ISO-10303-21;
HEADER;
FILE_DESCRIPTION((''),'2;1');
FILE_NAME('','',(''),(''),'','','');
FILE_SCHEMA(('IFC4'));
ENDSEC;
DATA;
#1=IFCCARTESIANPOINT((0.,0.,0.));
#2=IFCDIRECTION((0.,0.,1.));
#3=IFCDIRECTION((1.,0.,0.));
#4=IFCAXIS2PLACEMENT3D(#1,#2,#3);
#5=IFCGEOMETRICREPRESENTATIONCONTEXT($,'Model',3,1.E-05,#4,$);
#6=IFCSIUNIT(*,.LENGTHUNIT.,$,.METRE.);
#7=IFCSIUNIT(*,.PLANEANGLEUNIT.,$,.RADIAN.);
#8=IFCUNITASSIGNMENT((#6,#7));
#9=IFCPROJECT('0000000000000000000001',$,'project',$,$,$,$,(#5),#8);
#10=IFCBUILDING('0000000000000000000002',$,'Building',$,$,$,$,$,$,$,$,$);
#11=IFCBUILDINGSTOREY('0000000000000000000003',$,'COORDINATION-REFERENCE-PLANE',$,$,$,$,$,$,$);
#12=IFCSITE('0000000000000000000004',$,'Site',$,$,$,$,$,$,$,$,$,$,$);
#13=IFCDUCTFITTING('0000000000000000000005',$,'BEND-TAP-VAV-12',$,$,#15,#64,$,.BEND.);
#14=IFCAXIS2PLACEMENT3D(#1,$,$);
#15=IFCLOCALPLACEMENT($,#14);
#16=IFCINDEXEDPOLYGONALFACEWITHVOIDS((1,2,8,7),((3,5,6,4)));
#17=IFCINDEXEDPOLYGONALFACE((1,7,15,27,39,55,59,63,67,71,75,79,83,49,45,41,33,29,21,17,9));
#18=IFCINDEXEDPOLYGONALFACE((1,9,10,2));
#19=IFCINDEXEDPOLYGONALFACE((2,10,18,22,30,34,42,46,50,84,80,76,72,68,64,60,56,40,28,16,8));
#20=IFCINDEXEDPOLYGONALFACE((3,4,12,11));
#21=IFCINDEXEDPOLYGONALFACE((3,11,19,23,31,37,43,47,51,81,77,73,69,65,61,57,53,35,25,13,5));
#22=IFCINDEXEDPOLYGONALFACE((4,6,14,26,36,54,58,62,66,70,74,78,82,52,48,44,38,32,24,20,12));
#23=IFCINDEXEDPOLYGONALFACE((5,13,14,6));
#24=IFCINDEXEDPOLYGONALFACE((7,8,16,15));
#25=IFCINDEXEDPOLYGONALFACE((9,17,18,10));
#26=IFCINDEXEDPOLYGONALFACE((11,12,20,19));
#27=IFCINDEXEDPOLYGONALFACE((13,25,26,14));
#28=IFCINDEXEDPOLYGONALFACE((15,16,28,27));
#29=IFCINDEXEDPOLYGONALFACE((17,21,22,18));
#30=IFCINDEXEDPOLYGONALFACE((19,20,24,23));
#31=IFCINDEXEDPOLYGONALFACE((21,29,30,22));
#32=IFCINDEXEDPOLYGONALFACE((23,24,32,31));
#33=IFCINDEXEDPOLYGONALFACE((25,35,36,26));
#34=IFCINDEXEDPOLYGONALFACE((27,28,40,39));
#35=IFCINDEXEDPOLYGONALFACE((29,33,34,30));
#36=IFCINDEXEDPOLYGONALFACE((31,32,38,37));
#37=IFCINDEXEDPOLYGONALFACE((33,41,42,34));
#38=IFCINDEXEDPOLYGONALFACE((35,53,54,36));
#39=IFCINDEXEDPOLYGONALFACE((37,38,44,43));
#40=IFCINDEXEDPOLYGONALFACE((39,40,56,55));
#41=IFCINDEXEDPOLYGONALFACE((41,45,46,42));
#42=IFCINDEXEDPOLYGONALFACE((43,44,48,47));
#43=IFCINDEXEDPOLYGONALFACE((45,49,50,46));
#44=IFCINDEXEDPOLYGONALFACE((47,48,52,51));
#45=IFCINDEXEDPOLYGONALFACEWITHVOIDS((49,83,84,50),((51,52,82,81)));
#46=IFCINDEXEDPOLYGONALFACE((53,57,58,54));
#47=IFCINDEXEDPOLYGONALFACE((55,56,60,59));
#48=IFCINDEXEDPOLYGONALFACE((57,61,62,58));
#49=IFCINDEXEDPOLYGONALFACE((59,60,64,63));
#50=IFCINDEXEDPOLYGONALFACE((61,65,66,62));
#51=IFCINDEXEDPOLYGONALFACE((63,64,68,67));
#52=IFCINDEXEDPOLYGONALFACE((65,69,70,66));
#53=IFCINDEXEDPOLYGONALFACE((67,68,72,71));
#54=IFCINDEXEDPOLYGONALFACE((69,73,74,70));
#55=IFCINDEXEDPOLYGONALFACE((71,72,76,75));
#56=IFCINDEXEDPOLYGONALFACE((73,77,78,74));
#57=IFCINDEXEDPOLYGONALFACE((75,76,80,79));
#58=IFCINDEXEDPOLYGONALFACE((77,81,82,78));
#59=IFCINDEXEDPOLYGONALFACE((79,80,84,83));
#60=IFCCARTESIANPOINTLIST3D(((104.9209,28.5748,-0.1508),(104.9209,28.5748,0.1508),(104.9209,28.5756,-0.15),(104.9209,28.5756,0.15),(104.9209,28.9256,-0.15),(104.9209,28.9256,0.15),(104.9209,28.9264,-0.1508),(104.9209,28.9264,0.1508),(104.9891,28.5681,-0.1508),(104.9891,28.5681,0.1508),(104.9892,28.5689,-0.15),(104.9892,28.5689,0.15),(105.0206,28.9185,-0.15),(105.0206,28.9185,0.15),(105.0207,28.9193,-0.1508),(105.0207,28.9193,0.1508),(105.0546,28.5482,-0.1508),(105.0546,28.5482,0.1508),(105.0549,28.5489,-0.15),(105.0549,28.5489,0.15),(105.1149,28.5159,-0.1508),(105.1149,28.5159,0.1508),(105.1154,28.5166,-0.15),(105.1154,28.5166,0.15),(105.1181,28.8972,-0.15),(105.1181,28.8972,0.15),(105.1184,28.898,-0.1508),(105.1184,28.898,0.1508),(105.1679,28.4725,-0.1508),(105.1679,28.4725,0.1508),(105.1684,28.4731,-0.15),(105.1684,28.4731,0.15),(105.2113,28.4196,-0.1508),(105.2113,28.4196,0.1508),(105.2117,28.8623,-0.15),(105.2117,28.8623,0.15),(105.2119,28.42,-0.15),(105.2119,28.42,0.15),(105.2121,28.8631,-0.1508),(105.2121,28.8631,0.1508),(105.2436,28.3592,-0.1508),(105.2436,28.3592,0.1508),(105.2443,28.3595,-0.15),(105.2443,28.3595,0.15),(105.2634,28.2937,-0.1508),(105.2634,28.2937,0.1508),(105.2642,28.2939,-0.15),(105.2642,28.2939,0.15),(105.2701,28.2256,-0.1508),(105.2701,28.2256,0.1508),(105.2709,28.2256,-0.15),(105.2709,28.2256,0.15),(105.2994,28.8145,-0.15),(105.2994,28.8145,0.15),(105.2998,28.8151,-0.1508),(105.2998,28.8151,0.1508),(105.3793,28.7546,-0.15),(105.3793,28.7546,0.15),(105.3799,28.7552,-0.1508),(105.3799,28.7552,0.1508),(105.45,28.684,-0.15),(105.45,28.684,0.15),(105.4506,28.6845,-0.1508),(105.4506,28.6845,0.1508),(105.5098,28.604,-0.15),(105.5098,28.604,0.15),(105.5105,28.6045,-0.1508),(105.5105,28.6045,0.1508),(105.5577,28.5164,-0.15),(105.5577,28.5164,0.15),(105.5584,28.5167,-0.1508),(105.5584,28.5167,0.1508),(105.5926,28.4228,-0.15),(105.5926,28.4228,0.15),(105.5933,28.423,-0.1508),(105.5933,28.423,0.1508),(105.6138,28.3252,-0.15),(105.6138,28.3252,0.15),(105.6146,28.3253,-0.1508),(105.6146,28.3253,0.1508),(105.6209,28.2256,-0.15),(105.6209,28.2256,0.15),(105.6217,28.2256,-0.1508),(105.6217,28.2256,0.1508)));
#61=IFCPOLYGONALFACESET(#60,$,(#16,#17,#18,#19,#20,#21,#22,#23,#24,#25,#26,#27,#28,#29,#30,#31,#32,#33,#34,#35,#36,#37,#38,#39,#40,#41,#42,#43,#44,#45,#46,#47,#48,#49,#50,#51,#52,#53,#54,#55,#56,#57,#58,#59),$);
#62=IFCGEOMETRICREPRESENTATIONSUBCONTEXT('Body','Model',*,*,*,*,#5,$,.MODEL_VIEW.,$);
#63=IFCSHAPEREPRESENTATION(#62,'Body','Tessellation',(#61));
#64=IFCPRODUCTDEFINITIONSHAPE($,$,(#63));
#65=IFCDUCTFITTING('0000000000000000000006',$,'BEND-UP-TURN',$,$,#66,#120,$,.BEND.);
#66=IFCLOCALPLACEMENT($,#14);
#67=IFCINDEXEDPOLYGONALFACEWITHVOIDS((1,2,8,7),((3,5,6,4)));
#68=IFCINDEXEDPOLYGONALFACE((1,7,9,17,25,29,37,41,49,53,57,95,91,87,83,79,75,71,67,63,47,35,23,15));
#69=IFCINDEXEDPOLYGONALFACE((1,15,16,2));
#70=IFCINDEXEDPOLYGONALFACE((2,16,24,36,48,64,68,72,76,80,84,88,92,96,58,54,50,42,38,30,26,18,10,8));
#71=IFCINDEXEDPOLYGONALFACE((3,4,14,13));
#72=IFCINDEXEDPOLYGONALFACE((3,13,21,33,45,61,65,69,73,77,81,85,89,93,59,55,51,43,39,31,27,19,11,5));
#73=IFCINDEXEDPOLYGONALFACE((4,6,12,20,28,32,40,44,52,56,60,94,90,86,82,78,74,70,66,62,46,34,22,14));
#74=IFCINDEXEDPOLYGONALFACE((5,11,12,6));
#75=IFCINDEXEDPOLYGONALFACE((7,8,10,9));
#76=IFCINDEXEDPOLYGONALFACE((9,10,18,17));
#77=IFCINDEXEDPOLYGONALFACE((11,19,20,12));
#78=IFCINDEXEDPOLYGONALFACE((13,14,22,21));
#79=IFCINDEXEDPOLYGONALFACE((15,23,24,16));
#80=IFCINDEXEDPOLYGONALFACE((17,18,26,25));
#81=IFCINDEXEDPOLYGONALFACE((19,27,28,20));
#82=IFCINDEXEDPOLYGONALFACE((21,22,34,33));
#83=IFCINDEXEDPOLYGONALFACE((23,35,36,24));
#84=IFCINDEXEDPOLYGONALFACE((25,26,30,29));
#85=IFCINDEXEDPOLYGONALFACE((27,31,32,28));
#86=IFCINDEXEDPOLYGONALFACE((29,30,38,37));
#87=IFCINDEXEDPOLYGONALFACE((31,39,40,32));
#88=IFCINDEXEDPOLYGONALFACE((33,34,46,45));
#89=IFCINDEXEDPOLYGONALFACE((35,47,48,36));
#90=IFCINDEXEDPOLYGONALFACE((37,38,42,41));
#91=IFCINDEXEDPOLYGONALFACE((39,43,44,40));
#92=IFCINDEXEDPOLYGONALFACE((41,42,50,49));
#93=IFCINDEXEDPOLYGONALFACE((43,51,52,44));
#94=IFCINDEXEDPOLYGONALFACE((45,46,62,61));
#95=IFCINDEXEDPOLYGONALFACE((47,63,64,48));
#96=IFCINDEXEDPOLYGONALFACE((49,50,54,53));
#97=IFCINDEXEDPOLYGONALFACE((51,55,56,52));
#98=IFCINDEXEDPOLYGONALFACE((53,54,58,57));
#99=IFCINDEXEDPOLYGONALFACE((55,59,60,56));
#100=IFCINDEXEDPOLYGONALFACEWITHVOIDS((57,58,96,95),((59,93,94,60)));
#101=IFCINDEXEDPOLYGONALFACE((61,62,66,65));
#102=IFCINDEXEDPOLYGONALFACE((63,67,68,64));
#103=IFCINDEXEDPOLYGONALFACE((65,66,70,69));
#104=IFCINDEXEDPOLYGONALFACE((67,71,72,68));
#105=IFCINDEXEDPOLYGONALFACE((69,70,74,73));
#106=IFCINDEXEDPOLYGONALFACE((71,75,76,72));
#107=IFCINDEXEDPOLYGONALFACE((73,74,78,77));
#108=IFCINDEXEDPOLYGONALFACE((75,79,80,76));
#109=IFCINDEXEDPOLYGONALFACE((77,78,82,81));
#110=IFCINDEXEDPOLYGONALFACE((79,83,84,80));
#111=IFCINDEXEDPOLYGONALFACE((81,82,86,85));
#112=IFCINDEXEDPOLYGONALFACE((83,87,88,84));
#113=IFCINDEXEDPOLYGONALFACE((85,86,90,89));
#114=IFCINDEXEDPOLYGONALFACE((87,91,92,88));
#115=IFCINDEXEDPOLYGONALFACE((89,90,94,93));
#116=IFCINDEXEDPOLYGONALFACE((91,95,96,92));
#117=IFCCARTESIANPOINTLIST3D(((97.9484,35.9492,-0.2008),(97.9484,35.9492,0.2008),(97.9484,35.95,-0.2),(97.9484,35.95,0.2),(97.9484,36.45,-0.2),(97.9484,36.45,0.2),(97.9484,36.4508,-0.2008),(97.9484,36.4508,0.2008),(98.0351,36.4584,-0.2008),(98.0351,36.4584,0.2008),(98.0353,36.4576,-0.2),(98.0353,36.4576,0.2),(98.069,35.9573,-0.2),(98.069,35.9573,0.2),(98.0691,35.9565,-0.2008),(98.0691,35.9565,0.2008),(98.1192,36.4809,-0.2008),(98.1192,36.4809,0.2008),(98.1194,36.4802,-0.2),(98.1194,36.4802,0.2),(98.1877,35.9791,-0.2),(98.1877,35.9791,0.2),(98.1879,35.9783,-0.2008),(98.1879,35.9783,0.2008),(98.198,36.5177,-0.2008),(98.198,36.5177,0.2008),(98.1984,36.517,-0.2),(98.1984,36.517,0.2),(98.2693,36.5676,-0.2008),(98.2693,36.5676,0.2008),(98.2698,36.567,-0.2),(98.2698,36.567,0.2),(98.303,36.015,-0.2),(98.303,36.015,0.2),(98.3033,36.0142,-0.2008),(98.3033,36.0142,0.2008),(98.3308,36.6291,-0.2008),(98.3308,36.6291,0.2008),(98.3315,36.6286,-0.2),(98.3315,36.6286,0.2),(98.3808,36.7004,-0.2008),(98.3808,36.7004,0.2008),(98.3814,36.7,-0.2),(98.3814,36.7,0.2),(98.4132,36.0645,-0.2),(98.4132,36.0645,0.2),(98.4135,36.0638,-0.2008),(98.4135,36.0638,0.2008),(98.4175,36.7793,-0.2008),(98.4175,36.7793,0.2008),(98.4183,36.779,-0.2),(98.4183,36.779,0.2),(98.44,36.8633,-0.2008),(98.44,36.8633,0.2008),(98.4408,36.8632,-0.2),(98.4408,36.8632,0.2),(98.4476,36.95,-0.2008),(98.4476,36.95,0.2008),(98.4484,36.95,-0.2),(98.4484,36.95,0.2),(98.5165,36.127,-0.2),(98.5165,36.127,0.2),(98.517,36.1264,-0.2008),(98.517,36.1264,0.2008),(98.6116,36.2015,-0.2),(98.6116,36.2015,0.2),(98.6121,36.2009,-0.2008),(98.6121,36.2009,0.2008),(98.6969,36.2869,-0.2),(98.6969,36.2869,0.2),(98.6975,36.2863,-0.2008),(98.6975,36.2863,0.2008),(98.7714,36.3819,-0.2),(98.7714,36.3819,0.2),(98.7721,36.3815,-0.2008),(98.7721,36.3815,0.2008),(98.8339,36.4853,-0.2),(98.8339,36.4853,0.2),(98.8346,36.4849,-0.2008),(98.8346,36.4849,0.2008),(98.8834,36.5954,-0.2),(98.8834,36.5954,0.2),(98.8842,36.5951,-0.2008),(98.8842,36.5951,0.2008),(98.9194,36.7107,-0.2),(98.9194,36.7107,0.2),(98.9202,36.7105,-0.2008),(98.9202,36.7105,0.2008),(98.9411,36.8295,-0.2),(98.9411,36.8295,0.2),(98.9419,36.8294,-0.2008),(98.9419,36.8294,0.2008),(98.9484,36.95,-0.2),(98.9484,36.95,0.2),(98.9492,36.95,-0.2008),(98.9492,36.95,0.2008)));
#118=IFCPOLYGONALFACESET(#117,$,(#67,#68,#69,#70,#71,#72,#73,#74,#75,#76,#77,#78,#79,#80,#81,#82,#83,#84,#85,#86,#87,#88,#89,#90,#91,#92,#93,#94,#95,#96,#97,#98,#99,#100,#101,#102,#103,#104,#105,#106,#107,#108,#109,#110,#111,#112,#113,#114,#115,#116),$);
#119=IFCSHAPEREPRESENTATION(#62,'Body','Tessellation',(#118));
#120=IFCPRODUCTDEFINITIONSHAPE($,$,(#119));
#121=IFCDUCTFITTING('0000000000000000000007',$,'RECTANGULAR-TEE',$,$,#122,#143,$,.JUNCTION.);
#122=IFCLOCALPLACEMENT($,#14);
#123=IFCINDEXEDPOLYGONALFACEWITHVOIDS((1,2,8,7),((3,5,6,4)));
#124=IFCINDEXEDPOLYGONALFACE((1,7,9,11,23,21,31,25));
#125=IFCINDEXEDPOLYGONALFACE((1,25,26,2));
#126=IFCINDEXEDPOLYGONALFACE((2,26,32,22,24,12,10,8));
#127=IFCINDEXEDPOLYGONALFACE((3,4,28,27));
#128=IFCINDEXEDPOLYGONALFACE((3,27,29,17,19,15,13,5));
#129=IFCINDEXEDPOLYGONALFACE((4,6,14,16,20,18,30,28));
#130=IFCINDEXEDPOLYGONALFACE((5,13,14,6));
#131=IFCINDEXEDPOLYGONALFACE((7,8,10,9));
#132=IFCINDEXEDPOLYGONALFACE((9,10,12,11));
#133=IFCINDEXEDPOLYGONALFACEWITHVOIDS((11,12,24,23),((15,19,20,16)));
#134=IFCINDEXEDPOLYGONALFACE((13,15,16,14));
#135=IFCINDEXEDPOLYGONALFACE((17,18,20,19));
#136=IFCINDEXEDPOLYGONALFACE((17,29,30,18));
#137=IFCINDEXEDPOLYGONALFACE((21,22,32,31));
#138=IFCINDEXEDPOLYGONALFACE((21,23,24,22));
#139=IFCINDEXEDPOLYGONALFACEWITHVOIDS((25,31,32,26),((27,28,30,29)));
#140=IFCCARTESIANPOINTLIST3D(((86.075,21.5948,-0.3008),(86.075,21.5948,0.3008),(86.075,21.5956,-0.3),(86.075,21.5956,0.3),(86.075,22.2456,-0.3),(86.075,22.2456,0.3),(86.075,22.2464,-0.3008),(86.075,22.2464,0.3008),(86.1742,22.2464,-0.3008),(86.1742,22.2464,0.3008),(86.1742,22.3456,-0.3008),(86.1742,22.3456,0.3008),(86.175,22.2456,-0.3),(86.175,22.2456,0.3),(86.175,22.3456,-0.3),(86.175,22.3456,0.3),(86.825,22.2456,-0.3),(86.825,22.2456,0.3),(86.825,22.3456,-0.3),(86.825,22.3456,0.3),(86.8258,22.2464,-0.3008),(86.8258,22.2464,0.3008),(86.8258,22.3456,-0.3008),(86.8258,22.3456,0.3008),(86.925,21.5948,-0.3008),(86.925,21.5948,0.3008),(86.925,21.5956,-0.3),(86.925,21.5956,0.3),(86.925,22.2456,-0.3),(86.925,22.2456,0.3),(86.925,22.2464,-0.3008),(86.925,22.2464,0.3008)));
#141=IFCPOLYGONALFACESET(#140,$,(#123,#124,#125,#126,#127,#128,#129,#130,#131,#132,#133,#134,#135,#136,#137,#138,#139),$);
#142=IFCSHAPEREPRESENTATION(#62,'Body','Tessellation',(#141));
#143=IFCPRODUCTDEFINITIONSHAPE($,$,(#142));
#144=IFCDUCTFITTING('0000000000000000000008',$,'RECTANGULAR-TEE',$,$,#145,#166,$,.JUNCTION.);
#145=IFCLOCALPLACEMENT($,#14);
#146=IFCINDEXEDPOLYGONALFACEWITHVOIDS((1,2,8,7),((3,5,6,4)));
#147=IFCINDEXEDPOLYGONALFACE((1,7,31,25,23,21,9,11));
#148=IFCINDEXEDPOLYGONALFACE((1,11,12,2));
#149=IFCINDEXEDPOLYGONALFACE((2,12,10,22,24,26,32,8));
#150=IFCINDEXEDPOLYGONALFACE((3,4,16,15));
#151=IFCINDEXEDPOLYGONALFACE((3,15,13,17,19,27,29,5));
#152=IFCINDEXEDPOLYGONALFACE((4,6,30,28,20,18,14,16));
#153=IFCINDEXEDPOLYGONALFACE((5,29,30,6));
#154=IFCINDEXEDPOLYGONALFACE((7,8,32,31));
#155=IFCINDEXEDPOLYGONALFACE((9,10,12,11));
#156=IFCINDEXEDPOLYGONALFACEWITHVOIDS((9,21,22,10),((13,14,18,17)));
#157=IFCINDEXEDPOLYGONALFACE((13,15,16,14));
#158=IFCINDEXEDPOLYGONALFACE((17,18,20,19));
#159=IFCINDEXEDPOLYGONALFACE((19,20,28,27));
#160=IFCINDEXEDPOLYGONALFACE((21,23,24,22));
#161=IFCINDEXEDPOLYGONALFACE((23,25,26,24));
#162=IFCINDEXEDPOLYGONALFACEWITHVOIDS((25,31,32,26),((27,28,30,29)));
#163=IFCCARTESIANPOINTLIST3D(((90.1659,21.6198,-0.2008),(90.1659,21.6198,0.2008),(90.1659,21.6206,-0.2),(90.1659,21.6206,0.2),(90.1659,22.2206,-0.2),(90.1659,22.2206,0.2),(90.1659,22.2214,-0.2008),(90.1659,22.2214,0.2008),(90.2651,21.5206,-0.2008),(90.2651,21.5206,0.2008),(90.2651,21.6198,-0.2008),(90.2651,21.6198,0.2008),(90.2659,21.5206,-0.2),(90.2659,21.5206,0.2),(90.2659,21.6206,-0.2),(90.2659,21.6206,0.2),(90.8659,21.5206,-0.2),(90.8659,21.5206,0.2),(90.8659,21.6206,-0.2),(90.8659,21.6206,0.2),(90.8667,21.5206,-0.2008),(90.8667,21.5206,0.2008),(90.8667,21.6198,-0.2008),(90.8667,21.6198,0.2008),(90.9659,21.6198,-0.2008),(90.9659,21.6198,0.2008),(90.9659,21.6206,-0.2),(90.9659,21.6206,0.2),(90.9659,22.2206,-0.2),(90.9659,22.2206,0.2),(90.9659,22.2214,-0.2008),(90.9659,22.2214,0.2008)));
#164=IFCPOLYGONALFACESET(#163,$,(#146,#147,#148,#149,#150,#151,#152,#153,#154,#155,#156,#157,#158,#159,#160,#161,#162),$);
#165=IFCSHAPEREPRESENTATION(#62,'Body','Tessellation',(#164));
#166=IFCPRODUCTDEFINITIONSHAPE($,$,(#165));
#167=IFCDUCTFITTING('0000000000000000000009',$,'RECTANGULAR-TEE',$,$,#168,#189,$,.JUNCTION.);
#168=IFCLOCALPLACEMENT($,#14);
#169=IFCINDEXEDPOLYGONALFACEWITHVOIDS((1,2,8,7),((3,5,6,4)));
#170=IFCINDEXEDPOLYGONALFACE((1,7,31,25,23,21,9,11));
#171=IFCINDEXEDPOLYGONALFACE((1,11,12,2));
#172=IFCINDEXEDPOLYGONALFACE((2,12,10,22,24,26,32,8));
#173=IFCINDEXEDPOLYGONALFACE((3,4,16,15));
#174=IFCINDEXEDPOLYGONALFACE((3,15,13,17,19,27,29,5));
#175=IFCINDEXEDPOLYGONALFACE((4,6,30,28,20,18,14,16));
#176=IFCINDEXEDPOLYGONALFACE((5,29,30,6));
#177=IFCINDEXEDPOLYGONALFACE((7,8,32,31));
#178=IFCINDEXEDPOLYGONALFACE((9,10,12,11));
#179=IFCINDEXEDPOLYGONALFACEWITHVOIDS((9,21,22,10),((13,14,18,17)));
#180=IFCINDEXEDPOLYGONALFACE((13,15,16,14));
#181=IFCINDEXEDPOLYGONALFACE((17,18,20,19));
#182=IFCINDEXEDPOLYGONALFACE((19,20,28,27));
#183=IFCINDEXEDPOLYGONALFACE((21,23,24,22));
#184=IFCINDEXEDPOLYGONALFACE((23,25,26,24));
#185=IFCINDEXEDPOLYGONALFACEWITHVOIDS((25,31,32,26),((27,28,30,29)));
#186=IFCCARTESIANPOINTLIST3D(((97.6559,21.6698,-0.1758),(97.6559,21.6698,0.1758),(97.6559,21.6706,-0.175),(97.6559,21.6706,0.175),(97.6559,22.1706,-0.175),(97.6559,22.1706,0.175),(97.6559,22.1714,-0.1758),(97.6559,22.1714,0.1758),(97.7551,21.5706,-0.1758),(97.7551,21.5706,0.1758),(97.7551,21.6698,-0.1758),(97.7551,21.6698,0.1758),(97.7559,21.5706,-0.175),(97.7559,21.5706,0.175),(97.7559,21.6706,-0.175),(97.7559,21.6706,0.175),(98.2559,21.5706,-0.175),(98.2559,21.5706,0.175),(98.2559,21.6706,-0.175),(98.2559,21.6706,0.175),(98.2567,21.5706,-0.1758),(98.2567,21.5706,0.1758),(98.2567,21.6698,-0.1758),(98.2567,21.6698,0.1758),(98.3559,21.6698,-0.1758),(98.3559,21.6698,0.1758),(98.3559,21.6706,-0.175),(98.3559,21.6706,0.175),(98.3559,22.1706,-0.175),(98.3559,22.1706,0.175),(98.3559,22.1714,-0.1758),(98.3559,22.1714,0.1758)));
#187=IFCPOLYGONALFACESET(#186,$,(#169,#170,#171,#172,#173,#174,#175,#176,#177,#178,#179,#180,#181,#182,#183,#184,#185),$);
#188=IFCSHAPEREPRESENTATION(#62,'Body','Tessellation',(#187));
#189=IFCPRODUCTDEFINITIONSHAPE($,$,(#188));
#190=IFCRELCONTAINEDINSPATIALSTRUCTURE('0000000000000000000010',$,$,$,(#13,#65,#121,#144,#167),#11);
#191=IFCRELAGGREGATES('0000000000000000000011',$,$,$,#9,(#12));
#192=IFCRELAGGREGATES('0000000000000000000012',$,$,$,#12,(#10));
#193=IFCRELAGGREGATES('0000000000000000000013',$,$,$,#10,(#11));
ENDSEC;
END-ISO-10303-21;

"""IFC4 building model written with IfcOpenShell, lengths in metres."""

from ifc_helpers import new_model, entity, si_unit, frame, origin_with_axes, place, context, subcontext, project, spatial, rectangle, extrude, boolean, element, save


model = new_model("IFC4")

# Units and contexts
model_context = context("Model", 3, precision=1e-05, world=origin_with_axes())
body_context = subcontext(model_context, "Body", "Model", "MODEL_VIEW")
ifc_project = project(units=[si_unit("LENGTHUNIT", "METRE"), si_unit("PLANEANGLEUNIT", "RADIAN")], contexts=[model_context])

# Site, building, storey
site = spatial("IfcSite", under=ifc_project, Name="Site")
building = spatial("IfcBuilding", under=site, Name="Building")
storey = spatial("IfcBuildingStorey", under=building, Name="COORDINATION-REFERENCE-PLANE")

# Duct fittings
duct_fitting_1_placement = place(None, frame((104.9209, 28.2256, 0.0), z_axis=(0.0, 0.0, -1.0), x_axis=(0.0, 1.0, 0.0)))
cartesian_point_1 = entity("IfcCartesianPoint", [0.0, 0.0, 0.0])
element("IfcDuctFitting", 1, at=duct_fitting_1_placement, inside=storey, Name="BEND-TAP-VAV-12", PredefinedType="BEND", context=body_context, shape_type="SweptSolid", body=[
    entity("IfcRevolvedAreaSolid", entity("IfcRectangleHollowProfileDef", "AREA", None, entity("IfcAxis2Placement2D", entity("IfcCartesianPoint", [0.525, 0.0])), 0.3516, 0.3016, 0.0008), entity("IfcAxis2Placement3D", cartesian_point_1, entity("IfcDirection", [0.0, -1.0, 0.0]), entity("IfcDirection", [1.0, 0.0, 0.0])), entity("IfcAxis1Placement", cartesian_point_1, entity("IfcDirection", [0.0, 1.0, 0.0])), 1.570796),
])
duct_fitting_2_placement = place(None, frame((97.9484, 36.95, 0.0), z_axis=(0.0, 0.0, 1.0), x_axis=(0.0, -1.0, 0.0)))
cartesian_point_2 = entity("IfcCartesianPoint", [0.0, 0.0, 0.0])
element("IfcDuctFitting", 2, at=duct_fitting_2_placement, inside=storey, Name="BEND-UP-TURN", PredefinedType="BEND", context=body_context, shape_type="SweptSolid", body=[
    entity("IfcRevolvedAreaSolid", entity("IfcRectangleHollowProfileDef", "AREA", None, entity("IfcAxis2Placement2D", entity("IfcCartesianPoint", [0.75, 0.0])), 0.5016, 0.4016, 0.0008), entity("IfcAxis2Placement3D", cartesian_point_2, entity("IfcDirection", [0.0, -1.0, 0.0]), entity("IfcDirection", [1.0, 0.0, 0.0])), entity("IfcAxis1Placement", cartesian_point_2, entity("IfcDirection", [0.0, 1.0, 0.0])), 1.570796),
])
duct_fitting_3_placement = place(None, frame((86.5, 21.9206, 0.0), z_axis=(1.0, 0.0, 0.0), x_axis=(0.0, 1.0, 0.0)))
solid_1 = boolean("UNION", extrude(rectangle(XDim=0.65, YDim=0.6), frame((0.0, 0.0, -0.425), z_axis=(0.0, 0.0, 1.0), x_axis=(1.0, 0.0, 0.0)), (0.0, 0.0, 1.0), 0.85), extrude(rectangle(XDim=0.65, YDim=0.6), frame((0.0, 0.0, 0.0), z_axis=(1.0, 0.0, 0.0), x_axis=(0.0, 0.0, -1.0)), (0.0, 0.0, 1.0), 0.425))
element("IfcDuctFitting", 3, at=duct_fitting_3_placement, inside=storey, Name="RECTANGULAR-TEE", PredefinedType="JUNCTION", context=body_context, shape_type="CSG", body=[
    boolean("DIFFERENCE", boolean("UNION", extrude(rectangle(XDim=0.6516, YDim=0.6016), frame((0.0, 0.0, -0.425), z_axis=(0.0, 0.0, 1.0), x_axis=(1.0, 0.0, 0.0)), (0.0, 0.0, 1.0), 0.85), extrude(rectangle(XDim=0.6516, YDim=0.6016), frame((0.0, 0.0, 0.0), z_axis=(1.0, 0.0, 0.0), x_axis=(0.0, 0.0, -1.0)), (0.0, 0.0, 1.0), 0.425)), solid_1),
])
duct_fitting_4_placement = place(None, frame((90.5659, 21.9206, 0.0), z_axis=(1.0, 0.0, 0.0), x_axis=(0.0, -1.0, 0.0)))
solid_2 = boolean("UNION", extrude(rectangle(XDim=0.6, YDim=0.4), frame((0.0, 0.0, -0.4), z_axis=(0.0, 0.0, 1.0), x_axis=(1.0, 0.0, 0.0)), (0.0, 0.0, 1.0), 0.8), extrude(rectangle(XDim=0.6, YDim=0.4), frame((0.0, 0.0, 0.0), z_axis=(1.0, 0.0, 0.0), x_axis=(0.0, 0.0, -1.0)), (0.0, 0.0, 1.0), 0.4))
element("IfcDuctFitting", 4, at=duct_fitting_4_placement, inside=storey, Name="RECTANGULAR-TEE", PredefinedType="JUNCTION", context=body_context, shape_type="CSG", body=[
    boolean("DIFFERENCE", boolean("UNION", extrude(rectangle(XDim=0.6016, YDim=0.4016), frame((0.0, 0.0, -0.4), z_axis=(0.0, 0.0, 1.0), x_axis=(1.0, 0.0, 0.0)), (0.0, 0.0, 1.0), 0.8), extrude(rectangle(XDim=0.6016, YDim=0.4016), frame((0.0, 0.0, 0.0), z_axis=(1.0, 0.0, 0.0), x_axis=(0.0, 0.0, -1.0)), (0.0, 0.0, 1.0), 0.4)), solid_2),
])
duct_fitting_5_placement = place(None, frame((98.0059, 21.9206, 0.0), z_axis=(1.0, 0.0, 0.0), x_axis=(0.0, -1.0, 0.0)))
solid_3 = boolean("UNION", extrude(rectangle(XDim=0.5, YDim=0.35), frame((0.0, 0.0, -0.35), z_axis=(0.0, 0.0, 1.0), x_axis=(1.0, 0.0, 0.0)), (0.0, 0.0, 1.0), 0.7), extrude(rectangle(XDim=0.5, YDim=0.35), frame((0.0, 0.0, 0.0), z_axis=(1.0, 0.0, 0.0), x_axis=(0.0, 0.0, -1.0)), (0.0, 0.0, 1.0), 0.35))
element("IfcDuctFitting", 5, at=duct_fitting_5_placement, inside=storey, Name="RECTANGULAR-TEE", PredefinedType="JUNCTION", context=body_context, shape_type="CSG", body=[
    boolean("DIFFERENCE", boolean("UNION", extrude(rectangle(XDim=0.5016, YDim=0.3516), frame((0.0, 0.0, -0.35), z_axis=(0.0, 0.0, 1.0), x_axis=(1.0, 0.0, 0.0)), (0.0, 0.0, 1.0), 0.7), extrude(rectangle(XDim=0.5016, YDim=0.3516), frame((0.0, 0.0, 0.0), z_axis=(1.0, 0.0, 0.0), x_axis=(0.0, 0.0, -1.0)), (0.0, 0.0, 1.0), 0.35)), solid_3),
])

save(model, "model.ifc")
